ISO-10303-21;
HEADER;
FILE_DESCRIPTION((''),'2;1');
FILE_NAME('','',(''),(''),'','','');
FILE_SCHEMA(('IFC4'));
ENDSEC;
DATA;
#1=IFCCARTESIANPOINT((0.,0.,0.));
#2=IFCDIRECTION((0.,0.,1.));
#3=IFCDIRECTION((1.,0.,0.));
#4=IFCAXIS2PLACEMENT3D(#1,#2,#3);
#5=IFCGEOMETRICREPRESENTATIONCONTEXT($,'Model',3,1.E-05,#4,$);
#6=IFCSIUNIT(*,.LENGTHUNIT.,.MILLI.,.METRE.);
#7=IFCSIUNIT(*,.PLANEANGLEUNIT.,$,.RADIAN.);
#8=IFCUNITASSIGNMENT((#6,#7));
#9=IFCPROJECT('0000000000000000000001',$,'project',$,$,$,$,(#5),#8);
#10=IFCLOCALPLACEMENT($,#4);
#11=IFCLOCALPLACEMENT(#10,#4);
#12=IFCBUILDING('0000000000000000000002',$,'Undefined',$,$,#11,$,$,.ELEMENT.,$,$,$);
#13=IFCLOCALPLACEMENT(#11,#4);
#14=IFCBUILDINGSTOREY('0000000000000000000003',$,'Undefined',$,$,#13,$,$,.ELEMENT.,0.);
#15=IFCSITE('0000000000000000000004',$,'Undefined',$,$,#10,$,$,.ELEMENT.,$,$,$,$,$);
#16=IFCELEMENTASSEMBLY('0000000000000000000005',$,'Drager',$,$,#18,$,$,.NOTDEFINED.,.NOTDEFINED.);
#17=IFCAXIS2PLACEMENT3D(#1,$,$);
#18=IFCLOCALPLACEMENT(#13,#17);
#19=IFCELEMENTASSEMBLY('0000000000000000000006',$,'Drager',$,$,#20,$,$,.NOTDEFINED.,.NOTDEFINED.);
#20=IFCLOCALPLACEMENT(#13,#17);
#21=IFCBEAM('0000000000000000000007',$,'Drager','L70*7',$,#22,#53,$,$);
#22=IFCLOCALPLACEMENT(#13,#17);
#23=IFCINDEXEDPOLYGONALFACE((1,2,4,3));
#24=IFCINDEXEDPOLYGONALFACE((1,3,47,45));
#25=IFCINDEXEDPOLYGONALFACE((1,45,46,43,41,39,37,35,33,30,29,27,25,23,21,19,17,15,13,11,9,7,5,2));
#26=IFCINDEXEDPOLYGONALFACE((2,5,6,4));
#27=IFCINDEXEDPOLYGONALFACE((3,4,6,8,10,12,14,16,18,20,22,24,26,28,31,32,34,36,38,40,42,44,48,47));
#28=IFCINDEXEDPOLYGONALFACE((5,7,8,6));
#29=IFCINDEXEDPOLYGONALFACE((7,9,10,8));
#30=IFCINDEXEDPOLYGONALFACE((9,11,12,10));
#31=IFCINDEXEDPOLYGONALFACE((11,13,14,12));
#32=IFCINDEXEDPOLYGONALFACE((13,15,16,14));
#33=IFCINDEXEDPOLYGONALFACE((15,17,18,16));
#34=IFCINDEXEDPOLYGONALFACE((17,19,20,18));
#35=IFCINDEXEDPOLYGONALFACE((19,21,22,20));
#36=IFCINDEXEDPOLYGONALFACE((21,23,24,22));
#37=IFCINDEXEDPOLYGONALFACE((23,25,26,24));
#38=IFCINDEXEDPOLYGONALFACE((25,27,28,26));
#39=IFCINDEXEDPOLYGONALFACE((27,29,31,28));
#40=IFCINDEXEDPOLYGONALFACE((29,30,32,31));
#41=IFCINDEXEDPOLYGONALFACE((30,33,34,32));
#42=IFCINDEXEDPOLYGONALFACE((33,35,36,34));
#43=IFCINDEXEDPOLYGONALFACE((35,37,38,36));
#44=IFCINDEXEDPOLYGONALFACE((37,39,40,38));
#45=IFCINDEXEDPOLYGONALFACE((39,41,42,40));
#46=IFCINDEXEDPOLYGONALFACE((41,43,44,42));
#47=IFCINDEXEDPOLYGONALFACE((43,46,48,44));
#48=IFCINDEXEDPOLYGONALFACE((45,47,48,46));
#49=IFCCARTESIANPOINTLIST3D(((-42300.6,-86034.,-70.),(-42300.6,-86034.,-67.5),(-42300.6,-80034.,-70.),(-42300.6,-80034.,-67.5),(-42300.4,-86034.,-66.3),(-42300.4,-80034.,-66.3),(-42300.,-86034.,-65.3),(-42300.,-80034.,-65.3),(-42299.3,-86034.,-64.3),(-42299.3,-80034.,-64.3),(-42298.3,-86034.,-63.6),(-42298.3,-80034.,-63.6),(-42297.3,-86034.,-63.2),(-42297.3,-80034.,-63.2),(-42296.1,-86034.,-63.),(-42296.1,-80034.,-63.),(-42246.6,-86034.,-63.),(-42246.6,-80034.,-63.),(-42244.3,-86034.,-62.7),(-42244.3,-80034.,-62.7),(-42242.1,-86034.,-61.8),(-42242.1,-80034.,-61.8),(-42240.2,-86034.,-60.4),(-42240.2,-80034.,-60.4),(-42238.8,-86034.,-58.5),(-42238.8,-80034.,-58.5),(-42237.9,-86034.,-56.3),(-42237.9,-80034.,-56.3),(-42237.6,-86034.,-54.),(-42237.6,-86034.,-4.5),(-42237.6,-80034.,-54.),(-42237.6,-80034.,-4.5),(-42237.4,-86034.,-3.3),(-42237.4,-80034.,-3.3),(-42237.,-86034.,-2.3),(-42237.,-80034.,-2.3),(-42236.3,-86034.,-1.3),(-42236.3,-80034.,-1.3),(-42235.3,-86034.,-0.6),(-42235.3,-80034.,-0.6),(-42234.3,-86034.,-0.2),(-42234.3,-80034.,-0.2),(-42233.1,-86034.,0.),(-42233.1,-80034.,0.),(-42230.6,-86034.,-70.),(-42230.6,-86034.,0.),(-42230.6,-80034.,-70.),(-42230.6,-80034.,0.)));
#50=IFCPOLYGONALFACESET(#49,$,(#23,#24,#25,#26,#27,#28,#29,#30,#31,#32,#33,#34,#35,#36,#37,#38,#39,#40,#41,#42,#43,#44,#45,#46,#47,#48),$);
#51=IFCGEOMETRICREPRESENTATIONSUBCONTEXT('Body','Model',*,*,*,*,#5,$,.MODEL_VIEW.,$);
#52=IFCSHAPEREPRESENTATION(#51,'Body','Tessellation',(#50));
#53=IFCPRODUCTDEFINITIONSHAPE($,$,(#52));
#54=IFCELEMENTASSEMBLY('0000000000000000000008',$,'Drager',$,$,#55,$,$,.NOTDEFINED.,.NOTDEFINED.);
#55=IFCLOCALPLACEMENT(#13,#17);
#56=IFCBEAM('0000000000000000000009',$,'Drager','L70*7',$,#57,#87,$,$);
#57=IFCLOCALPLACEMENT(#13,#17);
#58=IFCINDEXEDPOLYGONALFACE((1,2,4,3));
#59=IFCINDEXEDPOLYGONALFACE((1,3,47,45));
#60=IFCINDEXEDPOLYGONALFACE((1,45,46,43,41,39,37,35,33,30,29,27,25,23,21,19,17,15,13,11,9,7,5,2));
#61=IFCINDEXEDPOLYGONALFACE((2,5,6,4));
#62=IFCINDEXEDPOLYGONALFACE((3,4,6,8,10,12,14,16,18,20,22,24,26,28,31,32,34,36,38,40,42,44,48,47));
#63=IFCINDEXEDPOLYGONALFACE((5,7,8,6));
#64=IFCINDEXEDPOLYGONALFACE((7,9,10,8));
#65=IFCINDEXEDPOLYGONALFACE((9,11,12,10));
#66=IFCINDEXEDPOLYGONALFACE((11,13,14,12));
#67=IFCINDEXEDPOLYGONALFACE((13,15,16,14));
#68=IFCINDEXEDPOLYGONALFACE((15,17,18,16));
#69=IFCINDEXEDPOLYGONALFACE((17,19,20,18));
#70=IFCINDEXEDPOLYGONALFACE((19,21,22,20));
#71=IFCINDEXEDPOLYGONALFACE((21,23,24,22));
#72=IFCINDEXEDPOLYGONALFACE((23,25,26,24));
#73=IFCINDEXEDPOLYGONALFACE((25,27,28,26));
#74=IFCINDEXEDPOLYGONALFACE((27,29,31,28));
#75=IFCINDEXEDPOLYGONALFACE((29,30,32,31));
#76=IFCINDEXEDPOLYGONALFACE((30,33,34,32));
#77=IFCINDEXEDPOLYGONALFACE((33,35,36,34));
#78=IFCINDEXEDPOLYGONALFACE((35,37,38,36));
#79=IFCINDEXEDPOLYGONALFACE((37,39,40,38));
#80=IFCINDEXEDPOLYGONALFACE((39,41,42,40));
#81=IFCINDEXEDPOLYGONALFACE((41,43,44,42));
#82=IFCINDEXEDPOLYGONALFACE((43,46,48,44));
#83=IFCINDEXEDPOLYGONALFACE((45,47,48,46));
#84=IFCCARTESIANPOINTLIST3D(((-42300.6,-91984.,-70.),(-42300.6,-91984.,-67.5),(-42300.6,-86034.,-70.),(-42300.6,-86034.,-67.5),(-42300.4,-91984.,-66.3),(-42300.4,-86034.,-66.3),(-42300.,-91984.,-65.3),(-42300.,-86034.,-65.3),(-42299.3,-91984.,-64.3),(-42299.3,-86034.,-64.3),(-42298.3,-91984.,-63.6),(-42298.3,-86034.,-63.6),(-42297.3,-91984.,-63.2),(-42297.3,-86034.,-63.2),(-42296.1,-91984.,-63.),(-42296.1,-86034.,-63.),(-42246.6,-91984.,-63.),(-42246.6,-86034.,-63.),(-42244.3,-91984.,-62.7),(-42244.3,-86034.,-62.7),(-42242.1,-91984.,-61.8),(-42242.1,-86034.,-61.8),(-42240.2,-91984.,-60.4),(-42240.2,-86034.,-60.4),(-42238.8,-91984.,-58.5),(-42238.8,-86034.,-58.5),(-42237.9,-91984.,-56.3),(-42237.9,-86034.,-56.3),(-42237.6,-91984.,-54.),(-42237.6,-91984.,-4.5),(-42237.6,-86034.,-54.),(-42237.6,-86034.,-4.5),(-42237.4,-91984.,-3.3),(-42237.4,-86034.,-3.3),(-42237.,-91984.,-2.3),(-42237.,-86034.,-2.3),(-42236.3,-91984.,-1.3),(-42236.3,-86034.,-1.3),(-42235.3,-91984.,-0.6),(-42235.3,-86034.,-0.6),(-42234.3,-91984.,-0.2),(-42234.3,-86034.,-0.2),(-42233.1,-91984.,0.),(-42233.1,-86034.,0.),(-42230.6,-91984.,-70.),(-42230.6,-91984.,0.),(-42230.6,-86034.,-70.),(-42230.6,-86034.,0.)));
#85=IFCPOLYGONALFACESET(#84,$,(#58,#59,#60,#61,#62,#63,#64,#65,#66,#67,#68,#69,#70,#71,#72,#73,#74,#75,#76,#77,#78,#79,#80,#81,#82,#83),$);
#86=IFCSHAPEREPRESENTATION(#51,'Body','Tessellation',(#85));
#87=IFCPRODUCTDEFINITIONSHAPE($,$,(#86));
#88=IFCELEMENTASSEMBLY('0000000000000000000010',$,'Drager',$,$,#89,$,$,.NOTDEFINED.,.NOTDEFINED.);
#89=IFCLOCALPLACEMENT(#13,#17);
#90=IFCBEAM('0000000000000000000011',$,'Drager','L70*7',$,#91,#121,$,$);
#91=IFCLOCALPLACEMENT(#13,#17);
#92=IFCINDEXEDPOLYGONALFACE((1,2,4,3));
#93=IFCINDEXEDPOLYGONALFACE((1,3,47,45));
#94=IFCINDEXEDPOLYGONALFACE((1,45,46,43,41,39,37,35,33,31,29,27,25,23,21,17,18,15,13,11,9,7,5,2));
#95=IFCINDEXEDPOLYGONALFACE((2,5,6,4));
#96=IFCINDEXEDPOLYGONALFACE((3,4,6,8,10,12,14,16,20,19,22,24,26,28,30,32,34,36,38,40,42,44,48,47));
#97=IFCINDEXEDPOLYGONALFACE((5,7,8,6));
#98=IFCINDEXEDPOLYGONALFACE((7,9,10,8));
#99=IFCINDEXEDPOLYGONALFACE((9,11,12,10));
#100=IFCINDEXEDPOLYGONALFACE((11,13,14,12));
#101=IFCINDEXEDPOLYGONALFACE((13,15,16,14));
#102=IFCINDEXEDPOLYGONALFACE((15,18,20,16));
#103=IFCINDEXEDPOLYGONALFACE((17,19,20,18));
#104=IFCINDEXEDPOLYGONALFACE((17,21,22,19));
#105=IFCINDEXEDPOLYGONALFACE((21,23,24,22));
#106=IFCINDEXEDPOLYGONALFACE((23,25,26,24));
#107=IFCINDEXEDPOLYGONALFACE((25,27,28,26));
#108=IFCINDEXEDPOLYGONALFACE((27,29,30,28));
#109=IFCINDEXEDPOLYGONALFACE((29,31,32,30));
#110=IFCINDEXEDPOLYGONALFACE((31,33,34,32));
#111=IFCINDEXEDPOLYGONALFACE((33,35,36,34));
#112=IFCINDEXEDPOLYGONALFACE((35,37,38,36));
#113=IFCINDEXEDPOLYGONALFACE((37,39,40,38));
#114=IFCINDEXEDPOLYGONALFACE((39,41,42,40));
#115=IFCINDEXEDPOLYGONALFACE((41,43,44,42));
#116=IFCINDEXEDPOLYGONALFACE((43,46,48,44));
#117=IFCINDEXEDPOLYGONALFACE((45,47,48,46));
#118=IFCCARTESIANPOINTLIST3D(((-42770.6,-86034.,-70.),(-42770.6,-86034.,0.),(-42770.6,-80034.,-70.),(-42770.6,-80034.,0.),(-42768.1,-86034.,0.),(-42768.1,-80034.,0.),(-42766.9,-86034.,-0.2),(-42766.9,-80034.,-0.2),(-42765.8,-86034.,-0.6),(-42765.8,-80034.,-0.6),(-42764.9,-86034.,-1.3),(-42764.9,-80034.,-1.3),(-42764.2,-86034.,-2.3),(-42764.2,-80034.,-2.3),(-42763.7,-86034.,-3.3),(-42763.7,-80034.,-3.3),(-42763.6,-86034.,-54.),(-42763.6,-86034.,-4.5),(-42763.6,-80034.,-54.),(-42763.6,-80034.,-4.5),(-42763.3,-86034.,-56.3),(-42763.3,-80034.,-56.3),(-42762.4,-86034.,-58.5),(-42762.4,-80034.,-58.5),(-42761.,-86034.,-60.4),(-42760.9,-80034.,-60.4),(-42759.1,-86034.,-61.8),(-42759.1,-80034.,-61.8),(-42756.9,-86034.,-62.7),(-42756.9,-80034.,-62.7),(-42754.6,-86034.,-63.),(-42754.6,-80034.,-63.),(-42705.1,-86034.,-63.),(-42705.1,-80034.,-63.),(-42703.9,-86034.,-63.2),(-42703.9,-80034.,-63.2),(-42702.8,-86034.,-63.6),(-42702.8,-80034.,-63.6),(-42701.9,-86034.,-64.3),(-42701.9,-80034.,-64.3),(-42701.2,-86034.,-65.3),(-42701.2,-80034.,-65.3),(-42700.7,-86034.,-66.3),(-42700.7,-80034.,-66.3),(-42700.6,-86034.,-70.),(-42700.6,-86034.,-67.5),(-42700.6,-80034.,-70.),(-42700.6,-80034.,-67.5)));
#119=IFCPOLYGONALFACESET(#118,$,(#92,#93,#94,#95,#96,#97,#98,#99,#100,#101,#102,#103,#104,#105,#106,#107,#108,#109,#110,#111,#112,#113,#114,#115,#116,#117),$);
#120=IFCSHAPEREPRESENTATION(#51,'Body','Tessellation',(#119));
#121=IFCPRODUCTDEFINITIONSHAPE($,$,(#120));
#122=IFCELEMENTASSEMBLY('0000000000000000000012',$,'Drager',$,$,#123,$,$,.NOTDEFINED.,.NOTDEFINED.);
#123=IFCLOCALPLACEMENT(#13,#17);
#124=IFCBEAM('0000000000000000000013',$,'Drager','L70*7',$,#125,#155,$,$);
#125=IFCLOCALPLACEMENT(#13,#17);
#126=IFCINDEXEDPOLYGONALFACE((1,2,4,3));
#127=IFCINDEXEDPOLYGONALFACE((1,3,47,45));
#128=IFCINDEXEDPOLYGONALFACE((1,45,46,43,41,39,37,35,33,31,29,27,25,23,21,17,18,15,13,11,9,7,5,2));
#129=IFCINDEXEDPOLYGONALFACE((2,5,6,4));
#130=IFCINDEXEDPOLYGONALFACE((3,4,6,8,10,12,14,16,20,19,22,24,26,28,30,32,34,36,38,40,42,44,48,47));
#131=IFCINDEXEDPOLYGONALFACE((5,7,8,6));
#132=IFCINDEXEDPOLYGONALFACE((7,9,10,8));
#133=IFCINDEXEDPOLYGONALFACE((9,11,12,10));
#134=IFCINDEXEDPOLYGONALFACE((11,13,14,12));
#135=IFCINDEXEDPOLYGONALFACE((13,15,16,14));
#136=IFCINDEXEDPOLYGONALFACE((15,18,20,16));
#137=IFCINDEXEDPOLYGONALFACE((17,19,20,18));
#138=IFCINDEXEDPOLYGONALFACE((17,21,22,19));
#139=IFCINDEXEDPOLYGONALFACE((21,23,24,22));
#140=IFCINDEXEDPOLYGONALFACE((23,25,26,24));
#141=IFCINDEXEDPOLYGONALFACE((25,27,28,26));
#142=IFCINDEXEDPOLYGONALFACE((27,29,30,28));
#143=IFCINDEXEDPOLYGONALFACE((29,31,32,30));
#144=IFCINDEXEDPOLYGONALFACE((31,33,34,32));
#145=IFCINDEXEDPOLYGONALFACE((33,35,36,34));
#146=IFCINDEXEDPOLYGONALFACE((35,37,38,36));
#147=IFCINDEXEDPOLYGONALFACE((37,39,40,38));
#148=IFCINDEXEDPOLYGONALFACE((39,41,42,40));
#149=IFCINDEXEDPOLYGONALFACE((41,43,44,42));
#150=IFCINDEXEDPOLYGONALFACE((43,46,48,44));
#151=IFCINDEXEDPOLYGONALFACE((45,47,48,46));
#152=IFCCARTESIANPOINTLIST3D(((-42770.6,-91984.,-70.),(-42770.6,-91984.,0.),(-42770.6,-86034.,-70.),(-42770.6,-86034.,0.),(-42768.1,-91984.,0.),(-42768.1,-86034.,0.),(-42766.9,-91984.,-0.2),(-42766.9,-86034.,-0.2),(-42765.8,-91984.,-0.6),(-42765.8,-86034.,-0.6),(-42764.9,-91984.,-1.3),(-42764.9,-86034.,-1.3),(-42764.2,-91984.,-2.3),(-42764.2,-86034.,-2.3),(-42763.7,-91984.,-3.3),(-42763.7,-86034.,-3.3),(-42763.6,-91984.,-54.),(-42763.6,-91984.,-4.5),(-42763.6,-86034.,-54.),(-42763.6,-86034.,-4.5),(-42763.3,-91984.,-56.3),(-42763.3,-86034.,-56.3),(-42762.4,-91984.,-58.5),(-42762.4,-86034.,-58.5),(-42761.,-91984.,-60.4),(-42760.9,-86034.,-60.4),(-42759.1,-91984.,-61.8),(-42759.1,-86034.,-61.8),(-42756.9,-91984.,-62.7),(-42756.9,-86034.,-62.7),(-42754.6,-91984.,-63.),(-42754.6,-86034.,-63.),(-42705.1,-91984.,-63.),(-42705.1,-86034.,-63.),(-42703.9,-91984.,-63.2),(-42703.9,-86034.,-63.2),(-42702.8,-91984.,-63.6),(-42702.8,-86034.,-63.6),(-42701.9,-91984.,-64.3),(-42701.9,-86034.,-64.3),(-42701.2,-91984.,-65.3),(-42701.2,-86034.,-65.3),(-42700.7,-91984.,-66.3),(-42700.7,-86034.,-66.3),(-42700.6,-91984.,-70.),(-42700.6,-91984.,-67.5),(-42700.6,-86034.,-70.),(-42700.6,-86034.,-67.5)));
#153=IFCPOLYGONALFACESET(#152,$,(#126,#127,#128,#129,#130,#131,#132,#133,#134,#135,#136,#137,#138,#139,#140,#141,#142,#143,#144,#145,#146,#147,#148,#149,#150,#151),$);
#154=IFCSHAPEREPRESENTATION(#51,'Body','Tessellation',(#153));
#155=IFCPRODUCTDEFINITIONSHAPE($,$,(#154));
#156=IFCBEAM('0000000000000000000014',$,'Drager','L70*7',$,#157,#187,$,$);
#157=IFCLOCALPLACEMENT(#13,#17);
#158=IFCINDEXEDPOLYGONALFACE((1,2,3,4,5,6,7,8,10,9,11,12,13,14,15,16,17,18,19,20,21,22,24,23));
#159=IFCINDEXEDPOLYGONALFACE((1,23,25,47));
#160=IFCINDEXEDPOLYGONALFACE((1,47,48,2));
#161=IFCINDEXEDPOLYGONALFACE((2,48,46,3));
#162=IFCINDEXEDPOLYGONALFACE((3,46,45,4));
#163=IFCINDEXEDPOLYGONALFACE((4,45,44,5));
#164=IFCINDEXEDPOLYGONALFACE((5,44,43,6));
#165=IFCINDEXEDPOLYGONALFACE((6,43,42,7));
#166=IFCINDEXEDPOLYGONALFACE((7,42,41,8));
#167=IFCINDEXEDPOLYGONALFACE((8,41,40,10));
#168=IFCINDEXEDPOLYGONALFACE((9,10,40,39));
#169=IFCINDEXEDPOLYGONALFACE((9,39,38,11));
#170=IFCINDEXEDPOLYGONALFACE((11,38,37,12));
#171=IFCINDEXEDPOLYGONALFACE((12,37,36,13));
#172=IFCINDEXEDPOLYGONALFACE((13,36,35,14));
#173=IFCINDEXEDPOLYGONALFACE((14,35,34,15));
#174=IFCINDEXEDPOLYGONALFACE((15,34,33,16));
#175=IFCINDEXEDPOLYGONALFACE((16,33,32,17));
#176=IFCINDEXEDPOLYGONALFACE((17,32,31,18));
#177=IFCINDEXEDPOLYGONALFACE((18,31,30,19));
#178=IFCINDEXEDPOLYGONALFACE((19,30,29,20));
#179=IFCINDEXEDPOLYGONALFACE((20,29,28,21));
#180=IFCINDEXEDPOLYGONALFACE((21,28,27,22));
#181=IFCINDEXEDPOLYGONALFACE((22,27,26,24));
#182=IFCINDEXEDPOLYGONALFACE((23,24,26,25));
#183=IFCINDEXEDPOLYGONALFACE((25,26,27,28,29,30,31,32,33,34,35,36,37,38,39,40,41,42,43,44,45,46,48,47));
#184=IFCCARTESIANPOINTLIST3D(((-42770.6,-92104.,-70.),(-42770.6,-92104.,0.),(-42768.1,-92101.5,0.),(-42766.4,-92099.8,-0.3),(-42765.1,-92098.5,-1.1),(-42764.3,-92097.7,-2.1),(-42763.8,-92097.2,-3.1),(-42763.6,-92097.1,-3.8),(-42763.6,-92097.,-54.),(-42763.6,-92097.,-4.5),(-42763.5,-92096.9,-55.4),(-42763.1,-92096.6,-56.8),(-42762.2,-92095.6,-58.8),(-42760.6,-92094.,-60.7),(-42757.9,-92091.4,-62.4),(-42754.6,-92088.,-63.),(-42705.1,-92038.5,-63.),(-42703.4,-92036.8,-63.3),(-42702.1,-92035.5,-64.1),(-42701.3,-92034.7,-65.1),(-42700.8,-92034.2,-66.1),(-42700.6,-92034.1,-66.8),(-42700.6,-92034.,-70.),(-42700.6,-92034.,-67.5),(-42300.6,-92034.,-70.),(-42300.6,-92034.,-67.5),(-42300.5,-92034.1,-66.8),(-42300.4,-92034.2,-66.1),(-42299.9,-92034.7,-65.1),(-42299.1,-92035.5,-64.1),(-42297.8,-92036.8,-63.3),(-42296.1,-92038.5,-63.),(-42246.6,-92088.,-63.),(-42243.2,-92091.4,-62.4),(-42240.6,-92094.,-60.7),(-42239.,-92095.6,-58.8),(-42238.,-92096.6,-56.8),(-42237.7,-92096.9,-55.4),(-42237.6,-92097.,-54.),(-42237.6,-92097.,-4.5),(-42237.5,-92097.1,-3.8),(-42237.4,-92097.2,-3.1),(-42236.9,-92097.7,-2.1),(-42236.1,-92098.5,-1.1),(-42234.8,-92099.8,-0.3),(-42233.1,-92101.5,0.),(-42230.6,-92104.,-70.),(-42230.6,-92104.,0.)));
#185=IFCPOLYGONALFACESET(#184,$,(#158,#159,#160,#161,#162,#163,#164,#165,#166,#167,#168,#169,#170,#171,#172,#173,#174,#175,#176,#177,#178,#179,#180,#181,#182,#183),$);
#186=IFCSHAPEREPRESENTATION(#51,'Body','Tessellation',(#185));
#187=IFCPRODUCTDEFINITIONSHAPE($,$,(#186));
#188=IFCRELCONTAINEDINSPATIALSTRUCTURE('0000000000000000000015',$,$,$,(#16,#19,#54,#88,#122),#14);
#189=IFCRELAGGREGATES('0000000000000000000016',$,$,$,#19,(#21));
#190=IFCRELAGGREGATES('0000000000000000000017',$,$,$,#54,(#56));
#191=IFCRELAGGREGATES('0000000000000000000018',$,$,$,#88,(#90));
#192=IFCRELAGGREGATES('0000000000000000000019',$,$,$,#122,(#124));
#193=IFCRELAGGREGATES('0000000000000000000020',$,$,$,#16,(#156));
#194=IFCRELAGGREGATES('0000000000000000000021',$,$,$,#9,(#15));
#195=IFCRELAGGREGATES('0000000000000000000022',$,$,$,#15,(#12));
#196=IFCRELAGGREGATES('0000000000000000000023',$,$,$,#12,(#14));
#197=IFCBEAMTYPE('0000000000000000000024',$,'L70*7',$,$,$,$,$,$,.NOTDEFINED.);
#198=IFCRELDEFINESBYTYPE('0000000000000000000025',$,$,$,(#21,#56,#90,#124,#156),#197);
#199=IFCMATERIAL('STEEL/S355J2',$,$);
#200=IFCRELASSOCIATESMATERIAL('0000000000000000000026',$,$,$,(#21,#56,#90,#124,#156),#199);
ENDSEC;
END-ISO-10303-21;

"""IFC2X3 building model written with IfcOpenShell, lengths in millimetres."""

from ifc_helpers import new_model, si_unit, frame, origin_with_axes, origin_2d_with_axis, place, context, subcontext, project, spatial, l_section, extrude, clip, halfspace, material, type_object, element, aggregate, save


model = new_model("IFC2X3")

# Units and contexts
model_context = context("Model", 3, precision=1e-05, world=origin_with_axes())
body_context = subcontext(model_context, "Body", "Model", "MODEL_VIEW")
ifc_project = project(units=[si_unit("LENGTHUNIT", "METRE", prefix="MILLI"), si_unit("PLANEANGLEUNIT", "RADIAN")], contexts=[model_context])

# Site, building, storey
site_placement = place(None, origin_with_axes())
site = spatial("IfcSite", under=ifc_project, at=site_placement, Name="Undefined", CompositionType="ELEMENT")
building_placement = place(site_placement, origin_with_axes())
building = spatial("IfcBuilding", under=site, at=building_placement, Name="Undefined", CompositionType="ELEMENT")
storey_placement = place(building_placement, origin_with_axes())
storey = spatial("IfcBuildingStorey", under=building, at=storey_placement, Name="Undefined", CompositionType="ELEMENT", Elevation=0.0)

# Element assembly
assembly_1_placement = place(storey_placement, origin_with_axes())
assembly_1 = element("IfcElementAssembly", 1, at=assembly_1_placement, inside=storey, Name="Drager", AssemblyPlace="NOTDEFINED", PredefinedType="NOTDEFINED")
ifc_material_1 = material(Name="STEEL/S355J2")
beam_type_1 = type_object("IfcBeamType", Name="L70*7", PredefinedType="NOTDEFINED")

# Element assemblies, beams
assembly_2_placement = place(storey_placement, origin_with_axes())
assembly_2 = element("IfcElementAssembly", 2, at=assembly_2_placement, inside=storey, Name="Drager", AssemblyPlace="NOTDEFINED", PredefinedType="NOTDEFINED")
beam_1_placement = place(assembly_2_placement, frame((-42265.6, -80034.0, -35.0), z_axis=(0.0, 0.0, 1.0), x_axis=(0.0, -1.0, 0.0)))
beam_1 = element("IfcBeam", 3, at=beam_1_placement, type_object=beam_type_1, material=ifc_material_1, Name="Drager", Description="L70*7", context=body_context, shape_type="SweptSolid", body=[
    extrude(l_section(Depth=70.0, Width=70.0, Thickness=7.0, FilletRadius=9.0, EdgeRadius=4.5, at=origin_2d_with_axis()), frame((6000.0, 0.0, 0.0), z_axis=(-1.0, 0.0, 0.0), x_axis=(0.0, -1.0, 0.0)), (0.0, 0.0, 1.0), 6000.0),
])
aggregate(assembly_2, [beam_1])
assembly_3_placement = place(storey_placement, origin_with_axes())
assembly_3 = element("IfcElementAssembly", 4, at=assembly_3_placement, inside=storey, Name="Drager", AssemblyPlace="NOTDEFINED", PredefinedType="NOTDEFINED")
beam_2_placement = place(assembly_3_placement, frame((-42265.6, -86034.0, -35.0), z_axis=(0.0, 0.0, 1.0), x_axis=(0.0, -1.0, 0.0)))
beam_2 = element("IfcBeam", 5, at=beam_2_placement, type_object=beam_type_1, material=ifc_material_1, Name="Drager", Description="L70*7", context=body_context, shape_type="SweptSolid", body=[
    extrude(l_section(Depth=70.0, Width=70.0, Thickness=7.0, FilletRadius=9.0, EdgeRadius=4.5, at=origin_2d_with_axis()), frame((5950.0, 0.0, 0.0), z_axis=(-1.0, 0.0, 0.0), x_axis=(0.0, -1.0, 0.0)), (0.0, 0.0, 1.0), 5950.0),
])
aggregate(assembly_3, [beam_2])
assembly_4_placement = place(storey_placement, origin_with_axes())
assembly_4 = element("IfcElementAssembly", 6, at=assembly_4_placement, inside=storey, Name="Drager", AssemblyPlace="NOTDEFINED", PredefinedType="NOTDEFINED")
beam_3_placement = place(assembly_4_placement, frame((-42735.6, -86034.0, -35.0), z_axis=(0.0, 0.0, 1.0), x_axis=(0.0, 1.0, 0.0)))
beam_3 = element("IfcBeam", 7, at=beam_3_placement, type_object=beam_type_1, material=ifc_material_1, Name="Drager", Description="L70*7", context=body_context, shape_type="SweptSolid", body=[
    extrude(l_section(Depth=70.0, Width=70.0, Thickness=7.0, FilletRadius=9.0, EdgeRadius=4.5, at=origin_2d_with_axis()), frame((6000.0, 0.0, 0.0), z_axis=(-1.0, 0.0, 0.0), x_axis=(0.0, -1.0, 0.0)), (0.0, 0.0, 1.0), 6000.0),
])
aggregate(assembly_4, [beam_3])
assembly_5_placement = place(storey_placement, origin_with_axes())
assembly_5 = element("IfcElementAssembly", 8, at=assembly_5_placement, inside=storey, Name="Drager", AssemblyPlace="NOTDEFINED", PredefinedType="NOTDEFINED")
beam_4_placement = place(assembly_5_placement, frame((-42735.6, -91984.0, -35.0), z_axis=(0.0, 0.0, 1.0), x_axis=(0.0, 1.0, 0.0)))
beam_4 = element("IfcBeam", 9, at=beam_4_placement, type_object=beam_type_1, material=ifc_material_1, Name="Drager", Description="L70*7", context=body_context, shape_type="SweptSolid", body=[
    extrude(l_section(Depth=70.0, Width=70.0, Thickness=7.0, FilletRadius=9.0, EdgeRadius=4.5, at=origin_2d_with_axis()), frame((5950.0, 0.0, 0.0), z_axis=(-1.0, 0.0, 0.0), x_axis=(0.0, -1.0, 0.0)), (0.0, 0.0, 1.0), 5950.0),
])
aggregate(assembly_5, [beam_4])

# Beam
beam_5_placement = place(assembly_1_placement, frame((-42300.6, -92069.0, -35.0), z_axis=(0.0, 0.0, 1.0), x_axis=(-1.0, 0.0, 0.0)))
beam_5 = element("IfcBeam", 10, at=beam_5_placement, type_object=beam_type_1, material=ifc_material_1, Name="Drager", Description="L70*7", context=body_context, shape_type="Clipping", body=[
    clip(clip(extrude(l_section(Depth=70.0, Width=70.0, Thickness=7.0, FilletRadius=9.0, EdgeRadius=4.5, at=origin_2d_with_axis()), frame((505.7, 0.0, 0.0), z_axis=(-1.0, 0.0, 0.0), x_axis=(0.0, -1.0, 0.0)), (0.0, 0.0, 1.0), 611.4), halfspace(frame((400.0, -35.0, 35.0), z_axis=(0.707107, -0.707107, 0.0), x_axis=(0.0, 0.0, 1.0)), False)), halfspace(frame((0.0, -35.0, 35.0), z_axis=(0.707107, 0.707107, 0.0), x_axis=(0.0, 0.0, 1.0)), True)),
])
aggregate(assembly_1, [beam_5])

save(model, "model.ifc")
